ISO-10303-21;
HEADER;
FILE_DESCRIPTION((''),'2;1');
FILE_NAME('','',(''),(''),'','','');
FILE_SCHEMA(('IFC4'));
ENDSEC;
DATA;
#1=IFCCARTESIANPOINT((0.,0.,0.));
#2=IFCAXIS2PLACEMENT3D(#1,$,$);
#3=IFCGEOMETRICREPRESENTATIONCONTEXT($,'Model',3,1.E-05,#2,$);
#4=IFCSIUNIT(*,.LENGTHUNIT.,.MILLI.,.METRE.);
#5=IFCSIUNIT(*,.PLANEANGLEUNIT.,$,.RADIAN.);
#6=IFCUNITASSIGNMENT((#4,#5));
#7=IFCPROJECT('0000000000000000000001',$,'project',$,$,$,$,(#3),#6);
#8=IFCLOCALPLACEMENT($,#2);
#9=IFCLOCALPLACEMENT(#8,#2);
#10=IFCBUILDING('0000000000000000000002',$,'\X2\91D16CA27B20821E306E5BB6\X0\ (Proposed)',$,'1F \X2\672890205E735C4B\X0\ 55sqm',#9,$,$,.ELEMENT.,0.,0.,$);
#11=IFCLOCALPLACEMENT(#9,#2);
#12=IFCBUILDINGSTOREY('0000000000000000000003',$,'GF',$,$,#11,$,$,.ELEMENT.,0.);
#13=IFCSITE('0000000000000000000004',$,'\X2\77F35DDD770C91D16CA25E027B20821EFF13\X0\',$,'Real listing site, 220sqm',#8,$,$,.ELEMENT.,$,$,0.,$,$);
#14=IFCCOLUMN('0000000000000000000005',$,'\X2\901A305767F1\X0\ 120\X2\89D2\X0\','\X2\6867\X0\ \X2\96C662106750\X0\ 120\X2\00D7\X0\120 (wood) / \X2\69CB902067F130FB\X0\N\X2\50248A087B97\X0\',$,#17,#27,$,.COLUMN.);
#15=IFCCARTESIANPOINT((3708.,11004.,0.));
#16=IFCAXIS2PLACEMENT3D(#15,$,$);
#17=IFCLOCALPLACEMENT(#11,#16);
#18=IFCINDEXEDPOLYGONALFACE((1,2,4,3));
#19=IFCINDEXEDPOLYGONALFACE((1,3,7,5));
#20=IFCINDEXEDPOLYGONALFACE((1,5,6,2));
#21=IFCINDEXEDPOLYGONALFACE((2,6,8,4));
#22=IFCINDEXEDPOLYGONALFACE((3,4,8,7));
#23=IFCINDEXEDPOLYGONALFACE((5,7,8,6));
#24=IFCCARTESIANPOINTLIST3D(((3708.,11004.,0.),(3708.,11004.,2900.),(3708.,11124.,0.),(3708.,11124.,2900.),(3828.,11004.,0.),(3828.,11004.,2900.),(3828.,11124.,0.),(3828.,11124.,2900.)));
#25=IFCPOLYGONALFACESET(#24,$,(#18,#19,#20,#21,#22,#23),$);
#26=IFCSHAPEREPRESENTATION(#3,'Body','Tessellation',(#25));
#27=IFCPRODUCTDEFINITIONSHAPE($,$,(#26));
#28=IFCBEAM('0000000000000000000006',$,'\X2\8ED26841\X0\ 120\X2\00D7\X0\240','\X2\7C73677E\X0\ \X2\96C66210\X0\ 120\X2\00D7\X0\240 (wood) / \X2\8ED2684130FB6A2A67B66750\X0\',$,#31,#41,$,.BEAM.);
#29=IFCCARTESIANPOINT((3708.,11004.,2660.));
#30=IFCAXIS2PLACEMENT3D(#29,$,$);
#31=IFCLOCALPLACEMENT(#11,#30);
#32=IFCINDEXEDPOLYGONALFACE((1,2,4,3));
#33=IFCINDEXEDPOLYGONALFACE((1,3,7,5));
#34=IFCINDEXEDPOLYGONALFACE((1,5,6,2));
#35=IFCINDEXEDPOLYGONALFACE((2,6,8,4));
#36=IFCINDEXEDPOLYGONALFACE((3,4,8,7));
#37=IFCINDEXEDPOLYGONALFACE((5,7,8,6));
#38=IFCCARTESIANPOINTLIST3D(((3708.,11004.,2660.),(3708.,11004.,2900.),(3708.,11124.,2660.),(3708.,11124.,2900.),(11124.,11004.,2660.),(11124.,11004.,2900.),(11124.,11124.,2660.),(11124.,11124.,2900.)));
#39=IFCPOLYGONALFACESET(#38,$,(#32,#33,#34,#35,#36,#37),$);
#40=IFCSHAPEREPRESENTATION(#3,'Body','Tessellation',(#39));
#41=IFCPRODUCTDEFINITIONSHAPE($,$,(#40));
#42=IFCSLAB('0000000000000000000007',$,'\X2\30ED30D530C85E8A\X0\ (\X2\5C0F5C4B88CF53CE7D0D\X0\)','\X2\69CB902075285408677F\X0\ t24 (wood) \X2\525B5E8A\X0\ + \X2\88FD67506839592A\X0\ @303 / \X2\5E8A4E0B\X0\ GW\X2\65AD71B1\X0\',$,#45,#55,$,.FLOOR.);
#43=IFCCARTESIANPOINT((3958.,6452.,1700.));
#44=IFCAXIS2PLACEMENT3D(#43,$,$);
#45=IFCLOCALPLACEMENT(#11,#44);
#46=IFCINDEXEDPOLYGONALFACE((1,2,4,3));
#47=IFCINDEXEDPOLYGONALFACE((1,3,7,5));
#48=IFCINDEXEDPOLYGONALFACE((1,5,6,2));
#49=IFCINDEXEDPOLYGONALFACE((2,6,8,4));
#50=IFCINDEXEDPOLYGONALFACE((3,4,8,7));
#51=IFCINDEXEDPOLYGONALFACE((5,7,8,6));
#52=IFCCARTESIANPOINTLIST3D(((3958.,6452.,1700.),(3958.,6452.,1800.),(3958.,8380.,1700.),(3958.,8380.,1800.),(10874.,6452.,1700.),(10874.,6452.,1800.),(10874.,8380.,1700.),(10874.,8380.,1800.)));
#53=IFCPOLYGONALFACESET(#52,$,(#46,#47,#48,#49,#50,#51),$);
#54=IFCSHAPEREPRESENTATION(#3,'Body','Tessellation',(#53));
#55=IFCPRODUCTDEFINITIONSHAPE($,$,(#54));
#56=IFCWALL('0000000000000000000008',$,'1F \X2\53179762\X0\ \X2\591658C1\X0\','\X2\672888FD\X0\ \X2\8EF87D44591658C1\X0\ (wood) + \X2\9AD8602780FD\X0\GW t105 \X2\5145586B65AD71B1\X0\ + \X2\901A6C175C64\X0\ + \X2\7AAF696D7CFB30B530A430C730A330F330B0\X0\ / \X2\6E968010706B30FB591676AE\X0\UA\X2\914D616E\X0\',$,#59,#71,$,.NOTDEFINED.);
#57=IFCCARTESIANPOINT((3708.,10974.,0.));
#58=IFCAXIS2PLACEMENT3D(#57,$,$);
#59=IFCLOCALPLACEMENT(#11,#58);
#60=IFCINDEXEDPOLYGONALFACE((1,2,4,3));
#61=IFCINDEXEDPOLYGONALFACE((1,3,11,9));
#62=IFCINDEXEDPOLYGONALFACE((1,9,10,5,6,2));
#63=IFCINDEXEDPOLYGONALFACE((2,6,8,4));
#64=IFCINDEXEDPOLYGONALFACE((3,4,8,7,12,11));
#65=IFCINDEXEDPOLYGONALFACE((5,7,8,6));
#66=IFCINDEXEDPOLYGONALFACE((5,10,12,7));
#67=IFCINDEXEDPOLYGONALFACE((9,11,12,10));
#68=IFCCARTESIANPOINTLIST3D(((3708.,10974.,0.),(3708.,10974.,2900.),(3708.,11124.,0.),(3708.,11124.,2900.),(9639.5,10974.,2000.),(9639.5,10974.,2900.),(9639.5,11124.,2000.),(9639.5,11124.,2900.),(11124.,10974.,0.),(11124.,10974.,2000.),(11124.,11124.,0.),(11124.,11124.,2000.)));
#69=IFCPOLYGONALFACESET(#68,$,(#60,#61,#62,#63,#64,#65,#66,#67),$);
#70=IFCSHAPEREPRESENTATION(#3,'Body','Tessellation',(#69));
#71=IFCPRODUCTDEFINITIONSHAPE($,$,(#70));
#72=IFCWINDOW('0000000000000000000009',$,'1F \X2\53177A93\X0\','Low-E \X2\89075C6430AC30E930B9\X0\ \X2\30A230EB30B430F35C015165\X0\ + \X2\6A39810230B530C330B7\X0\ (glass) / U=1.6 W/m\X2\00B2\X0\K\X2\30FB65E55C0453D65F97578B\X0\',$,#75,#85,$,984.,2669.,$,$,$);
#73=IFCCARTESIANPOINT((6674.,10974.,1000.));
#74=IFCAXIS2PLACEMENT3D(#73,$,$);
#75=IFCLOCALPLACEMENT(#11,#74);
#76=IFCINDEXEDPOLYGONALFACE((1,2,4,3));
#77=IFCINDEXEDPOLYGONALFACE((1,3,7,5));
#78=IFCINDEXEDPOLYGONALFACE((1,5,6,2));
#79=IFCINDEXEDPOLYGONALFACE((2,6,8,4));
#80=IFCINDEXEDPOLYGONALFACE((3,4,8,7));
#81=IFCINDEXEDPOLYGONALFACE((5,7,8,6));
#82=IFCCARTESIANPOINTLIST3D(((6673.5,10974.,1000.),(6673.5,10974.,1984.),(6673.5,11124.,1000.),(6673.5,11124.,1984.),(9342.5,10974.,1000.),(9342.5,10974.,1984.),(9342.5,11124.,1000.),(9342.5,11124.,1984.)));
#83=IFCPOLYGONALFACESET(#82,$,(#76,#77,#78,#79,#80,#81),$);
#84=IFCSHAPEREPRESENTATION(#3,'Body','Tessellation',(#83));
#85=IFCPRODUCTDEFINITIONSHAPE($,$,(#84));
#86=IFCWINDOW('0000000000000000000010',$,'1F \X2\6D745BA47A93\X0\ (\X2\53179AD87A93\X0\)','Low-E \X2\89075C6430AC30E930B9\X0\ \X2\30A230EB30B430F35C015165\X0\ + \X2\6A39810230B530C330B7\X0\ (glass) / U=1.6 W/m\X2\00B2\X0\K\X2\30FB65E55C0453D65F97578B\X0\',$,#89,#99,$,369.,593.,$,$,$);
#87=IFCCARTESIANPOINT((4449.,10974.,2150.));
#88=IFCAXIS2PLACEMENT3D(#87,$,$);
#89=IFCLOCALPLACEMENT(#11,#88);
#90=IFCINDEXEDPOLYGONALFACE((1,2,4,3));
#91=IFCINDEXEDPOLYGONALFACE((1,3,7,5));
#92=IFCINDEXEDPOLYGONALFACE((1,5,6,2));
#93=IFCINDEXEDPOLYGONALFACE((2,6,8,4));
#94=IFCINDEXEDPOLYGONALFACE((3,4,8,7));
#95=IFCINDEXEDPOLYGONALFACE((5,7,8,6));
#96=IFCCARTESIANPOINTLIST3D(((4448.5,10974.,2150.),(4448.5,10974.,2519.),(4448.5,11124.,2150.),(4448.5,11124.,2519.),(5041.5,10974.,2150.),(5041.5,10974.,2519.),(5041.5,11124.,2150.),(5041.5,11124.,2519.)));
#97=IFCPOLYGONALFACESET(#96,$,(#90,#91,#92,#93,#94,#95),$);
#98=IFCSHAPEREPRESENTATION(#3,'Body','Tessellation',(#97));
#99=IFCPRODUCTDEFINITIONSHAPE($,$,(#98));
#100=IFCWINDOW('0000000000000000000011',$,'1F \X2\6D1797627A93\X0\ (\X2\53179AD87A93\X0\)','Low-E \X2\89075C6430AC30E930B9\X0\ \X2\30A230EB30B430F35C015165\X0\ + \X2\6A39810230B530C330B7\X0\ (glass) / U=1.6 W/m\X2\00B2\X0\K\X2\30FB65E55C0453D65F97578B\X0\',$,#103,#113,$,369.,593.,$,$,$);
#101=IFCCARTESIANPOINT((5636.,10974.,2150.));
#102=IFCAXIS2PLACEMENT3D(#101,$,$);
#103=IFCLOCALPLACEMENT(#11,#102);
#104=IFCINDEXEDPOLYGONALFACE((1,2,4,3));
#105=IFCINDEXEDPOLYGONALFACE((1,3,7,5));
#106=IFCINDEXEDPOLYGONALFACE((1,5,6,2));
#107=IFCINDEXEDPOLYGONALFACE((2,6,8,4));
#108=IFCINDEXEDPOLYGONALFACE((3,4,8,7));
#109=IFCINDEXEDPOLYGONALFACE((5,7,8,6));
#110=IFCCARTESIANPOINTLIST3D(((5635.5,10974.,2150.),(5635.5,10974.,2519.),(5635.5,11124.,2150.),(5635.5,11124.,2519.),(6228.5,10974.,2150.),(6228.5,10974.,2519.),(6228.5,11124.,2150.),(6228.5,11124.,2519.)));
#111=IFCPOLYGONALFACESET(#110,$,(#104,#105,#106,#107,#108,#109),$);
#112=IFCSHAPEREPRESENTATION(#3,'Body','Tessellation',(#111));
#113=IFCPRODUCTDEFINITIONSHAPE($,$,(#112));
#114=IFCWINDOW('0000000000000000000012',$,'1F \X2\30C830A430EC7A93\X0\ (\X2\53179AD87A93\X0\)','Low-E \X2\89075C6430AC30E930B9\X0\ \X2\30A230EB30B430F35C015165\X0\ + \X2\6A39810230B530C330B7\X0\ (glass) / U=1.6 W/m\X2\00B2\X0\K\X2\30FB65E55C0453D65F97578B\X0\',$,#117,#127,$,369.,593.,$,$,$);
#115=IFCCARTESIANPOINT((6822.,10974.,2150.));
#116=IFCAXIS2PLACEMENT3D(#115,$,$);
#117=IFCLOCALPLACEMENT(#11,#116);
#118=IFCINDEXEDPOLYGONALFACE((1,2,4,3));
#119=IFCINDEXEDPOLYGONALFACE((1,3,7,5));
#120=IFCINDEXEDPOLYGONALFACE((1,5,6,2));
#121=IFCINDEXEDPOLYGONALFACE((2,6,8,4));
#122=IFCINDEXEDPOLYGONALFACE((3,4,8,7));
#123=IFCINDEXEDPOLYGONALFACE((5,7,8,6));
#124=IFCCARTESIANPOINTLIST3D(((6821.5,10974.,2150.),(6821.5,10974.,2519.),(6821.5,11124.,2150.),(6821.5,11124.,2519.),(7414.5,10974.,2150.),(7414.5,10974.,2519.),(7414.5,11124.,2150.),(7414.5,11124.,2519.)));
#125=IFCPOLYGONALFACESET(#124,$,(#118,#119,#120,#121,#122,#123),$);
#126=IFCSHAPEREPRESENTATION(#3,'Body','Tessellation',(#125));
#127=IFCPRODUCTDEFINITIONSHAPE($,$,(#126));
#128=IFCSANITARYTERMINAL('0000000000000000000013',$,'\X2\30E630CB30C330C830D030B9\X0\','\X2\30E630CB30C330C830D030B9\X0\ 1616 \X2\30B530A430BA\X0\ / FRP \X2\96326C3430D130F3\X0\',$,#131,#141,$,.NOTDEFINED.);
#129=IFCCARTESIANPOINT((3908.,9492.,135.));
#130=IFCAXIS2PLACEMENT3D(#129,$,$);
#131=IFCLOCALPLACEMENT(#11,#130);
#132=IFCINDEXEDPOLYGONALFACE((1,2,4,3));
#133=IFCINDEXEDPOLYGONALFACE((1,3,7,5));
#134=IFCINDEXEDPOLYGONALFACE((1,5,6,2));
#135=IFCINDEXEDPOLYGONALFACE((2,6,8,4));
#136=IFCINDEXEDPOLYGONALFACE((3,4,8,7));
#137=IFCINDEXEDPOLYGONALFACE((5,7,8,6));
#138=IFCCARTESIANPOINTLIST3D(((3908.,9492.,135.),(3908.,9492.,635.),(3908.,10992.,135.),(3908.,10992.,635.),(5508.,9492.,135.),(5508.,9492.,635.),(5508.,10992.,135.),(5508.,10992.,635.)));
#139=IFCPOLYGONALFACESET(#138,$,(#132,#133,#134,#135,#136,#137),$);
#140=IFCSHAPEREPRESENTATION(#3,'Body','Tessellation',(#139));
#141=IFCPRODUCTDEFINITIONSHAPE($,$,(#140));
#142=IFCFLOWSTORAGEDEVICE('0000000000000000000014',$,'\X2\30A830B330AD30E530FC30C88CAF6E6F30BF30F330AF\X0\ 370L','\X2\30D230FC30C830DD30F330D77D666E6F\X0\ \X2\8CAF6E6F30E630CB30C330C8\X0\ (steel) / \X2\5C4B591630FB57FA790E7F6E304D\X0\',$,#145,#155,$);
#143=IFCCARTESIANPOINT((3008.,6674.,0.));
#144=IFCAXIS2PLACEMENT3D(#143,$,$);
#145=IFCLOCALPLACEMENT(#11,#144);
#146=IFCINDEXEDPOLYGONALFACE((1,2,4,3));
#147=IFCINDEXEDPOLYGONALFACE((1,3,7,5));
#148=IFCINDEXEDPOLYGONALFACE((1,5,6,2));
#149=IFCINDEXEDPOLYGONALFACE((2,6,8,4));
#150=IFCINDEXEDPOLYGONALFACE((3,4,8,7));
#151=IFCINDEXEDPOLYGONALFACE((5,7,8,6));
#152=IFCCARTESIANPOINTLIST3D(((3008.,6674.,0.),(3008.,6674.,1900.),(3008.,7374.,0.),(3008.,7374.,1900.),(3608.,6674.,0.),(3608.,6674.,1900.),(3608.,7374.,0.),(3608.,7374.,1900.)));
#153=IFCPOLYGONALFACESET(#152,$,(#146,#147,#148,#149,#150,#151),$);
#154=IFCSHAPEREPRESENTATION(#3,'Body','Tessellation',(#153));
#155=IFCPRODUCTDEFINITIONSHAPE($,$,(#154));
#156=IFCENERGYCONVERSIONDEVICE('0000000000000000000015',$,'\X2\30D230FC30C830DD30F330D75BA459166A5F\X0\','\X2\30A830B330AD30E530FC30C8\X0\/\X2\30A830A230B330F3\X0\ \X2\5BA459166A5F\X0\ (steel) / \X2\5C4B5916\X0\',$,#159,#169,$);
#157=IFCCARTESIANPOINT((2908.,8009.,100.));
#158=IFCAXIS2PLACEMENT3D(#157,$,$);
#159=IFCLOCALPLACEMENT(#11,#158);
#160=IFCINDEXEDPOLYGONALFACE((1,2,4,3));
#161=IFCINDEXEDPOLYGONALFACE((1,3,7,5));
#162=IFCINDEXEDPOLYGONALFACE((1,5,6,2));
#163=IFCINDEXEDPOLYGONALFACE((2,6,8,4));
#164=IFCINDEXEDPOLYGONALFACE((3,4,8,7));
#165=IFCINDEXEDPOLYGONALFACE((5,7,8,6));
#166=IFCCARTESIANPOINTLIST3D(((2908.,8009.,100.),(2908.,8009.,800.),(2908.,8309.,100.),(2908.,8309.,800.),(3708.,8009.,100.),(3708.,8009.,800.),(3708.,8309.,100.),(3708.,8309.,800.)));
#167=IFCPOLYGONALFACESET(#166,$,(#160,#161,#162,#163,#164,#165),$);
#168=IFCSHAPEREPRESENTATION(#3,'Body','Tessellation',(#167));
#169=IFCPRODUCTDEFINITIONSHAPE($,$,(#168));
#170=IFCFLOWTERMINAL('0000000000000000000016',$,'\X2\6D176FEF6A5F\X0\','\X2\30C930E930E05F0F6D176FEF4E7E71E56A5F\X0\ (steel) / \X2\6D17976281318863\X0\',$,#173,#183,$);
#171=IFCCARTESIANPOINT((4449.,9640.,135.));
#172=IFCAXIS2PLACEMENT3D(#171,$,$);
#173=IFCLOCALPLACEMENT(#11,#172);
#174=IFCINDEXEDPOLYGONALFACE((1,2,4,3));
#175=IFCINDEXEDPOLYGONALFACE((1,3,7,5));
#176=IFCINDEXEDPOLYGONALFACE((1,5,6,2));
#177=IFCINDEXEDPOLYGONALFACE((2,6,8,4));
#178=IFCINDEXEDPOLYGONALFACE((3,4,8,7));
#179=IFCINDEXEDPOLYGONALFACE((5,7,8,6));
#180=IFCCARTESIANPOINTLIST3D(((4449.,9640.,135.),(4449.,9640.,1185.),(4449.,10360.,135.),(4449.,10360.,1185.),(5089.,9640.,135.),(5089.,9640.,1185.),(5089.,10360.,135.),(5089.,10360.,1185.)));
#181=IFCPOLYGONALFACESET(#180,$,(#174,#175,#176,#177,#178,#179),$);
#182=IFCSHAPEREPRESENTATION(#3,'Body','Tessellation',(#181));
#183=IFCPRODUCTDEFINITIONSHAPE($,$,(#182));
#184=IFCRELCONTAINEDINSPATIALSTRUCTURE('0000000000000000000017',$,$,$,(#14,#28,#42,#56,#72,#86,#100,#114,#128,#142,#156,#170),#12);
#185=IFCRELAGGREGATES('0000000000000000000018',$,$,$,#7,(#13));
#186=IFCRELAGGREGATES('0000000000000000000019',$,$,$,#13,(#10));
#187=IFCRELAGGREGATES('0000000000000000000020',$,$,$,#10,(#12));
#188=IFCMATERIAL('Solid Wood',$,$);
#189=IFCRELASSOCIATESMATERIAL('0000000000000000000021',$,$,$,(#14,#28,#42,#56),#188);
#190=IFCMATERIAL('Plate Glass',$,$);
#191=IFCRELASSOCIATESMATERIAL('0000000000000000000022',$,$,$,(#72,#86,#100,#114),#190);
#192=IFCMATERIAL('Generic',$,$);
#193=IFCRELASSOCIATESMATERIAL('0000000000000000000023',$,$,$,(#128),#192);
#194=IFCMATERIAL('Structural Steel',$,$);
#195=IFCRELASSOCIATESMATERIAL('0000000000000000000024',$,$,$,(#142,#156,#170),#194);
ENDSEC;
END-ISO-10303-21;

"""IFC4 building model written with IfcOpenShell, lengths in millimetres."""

from ifc_helpers import new_model, si_unit, frame, frame_2d, origin, place, context, project, spatial, rectangle, extrude, material, element, fill, save


model = new_model("IFC4")

# Units and contexts
model_context = context("Model", 3, precision=1e-05, world=origin())
ifc_project = project(units=[si_unit("LENGTHUNIT", "METRE", prefix="MILLI"), si_unit("PLANEANGLEUNIT", "RADIAN")], contexts=[model_context])

# Site, building, storey
site_placement = place(None, origin())
site = spatial("IfcSite", under=ifc_project, at=site_placement, Name="石川県金沢市笠舞３", ObjectType="Real listing site, 220sqm", CompositionType="ELEMENT", RefElevation=0.0)
building_placement = place(site_placement, origin())
building = spatial("IfcBuilding", under=site, at=building_placement, Name="金沢笠舞の家 (Proposed)", ObjectType="1F 木造平屋 55sqm", CompositionType="ELEMENT", ElevationOfRefHeight=0.0, ElevationOfTerrain=0.0)
storey_placement = place(building_placement, origin())
storey = spatial("IfcBuildingStorey", under=building, at=storey_placement, Name="GF", CompositionType="ELEMENT", Elevation=0.0)

# Column
ifc_material_1 = material(Name="Solid Wood")
column_1_placement = place(storey_placement, frame((3708.0, 11004.0, 0.0)))
element("IfcColumn", 1, at=column_1_placement, inside=storey, material=ifc_material_1, Name="通し柱 120角", Description="桧 集成材 120×120 (wood) / 構造柱・N値計算", PredefinedType="COLUMN", context=model_context, shape_type="SweptSolid", body=[
    extrude(rectangle(XDim=120.0, YDim=120.0, at=frame_2d((60.0, 60.0))), frame((3708.0, 11004.0, 0.0)), (0.0, 0.0, 1.0), 2900.0),
])

# Beam
beam_1_placement = place(storey_placement, frame((3708.0, 11004.0, 2660.0)))
element("IfcBeam", 2, at=beam_1_placement, inside=storey, material=ifc_material_1, Name="軒桁 120×240", Description="米松 集成 120×240 (wood) / 軒桁・横架材", PredefinedType="BEAM", context=model_context, shape_type="SweptSolid", body=[
    extrude(rectangle(XDim=7416.0, YDim=120.0, at=frame_2d((3708.0, 60.0))), frame((3708.0, 11004.0, 2660.0)), (0.0, 0.0, 1.0), 240.0),
])

# Slab
slab_placement = place(storey_placement, frame((3958.0, 6452.0, 1700.0)))
element("IfcSlab", 3, at=slab_placement, inside=storey, material=ifc_material_1, Name="ロフト床 (小屋裏収納)", Description="構造用合板 t24 (wood) 剛床 + 製材根太 @303 / 床下 GW断熱", PredefinedType="FLOOR", context=model_context, shape_type="SweptSolid", body=[
    extrude(rectangle(XDim=6916.0, YDim=1928.0, at=frame_2d((3458.0, 964.0))), frame((3958.0, 6452.0, 1700.0)), (0.0, 0.0, 1.0), 100.0),
])

# Wall, openings, windows
wall_1_placement = place(storey_placement, frame((3708.0, 10974.0, 0.0)))
wall_1 = element("IfcWall", 4, at=wall_1_placement, inside=storey, material=ifc_material_1, Name="1F 北面 外壁", Description="木製 軸組外壁 (wood) + 高性能GW t105 充填断熱 + 通気層 + 窯業系サイディング / 準耐火・外皮UA配慮", PredefinedType="NOTDEFINED", context=model_context, shape_type="SweptSolid", body=[
    extrude(rectangle(XDim=7416.0, YDim=150.0, at=frame_2d((3708.0, 75.0))), frame((3708.0, 10974.0, 0.0)), (0.0, 0.0, 1.0), 2900.0),
])
opening_1_placement = place(storey_placement, frame((6674.0, 10974.0, 1000.0)))
opening_1 = element("IfcOpeningElement", 5, at=opening_1_placement, cuts=wall_1, PredefinedType="NOTDEFINED", context=model_context, shape_type="SweptSolid", body=[
    extrude(rectangle(XDim=2669.0, YDim=150.0, at=frame_2d((1334.0, 75.0))), frame((6674.0, 10974.0, 1000.0)), (0.0, 0.0, 1.0), 984.0),
])
opening_2_placement = place(storey_placement, frame((4449.0, 10974.0, 2150.0)))
opening_2 = element("IfcOpeningElement", 6, at=opening_2_placement, cuts=wall_1, PredefinedType="NOTDEFINED", context=model_context, shape_type="SweptSolid", body=[
    extrude(rectangle(XDim=593.0, YDim=150.0, at=frame_2d((296.0, 75.0))), frame((4449.0, 10974.0, 2150.0)), (0.0, 0.0, 1.0), 369.0),
])
opening_3_placement = place(storey_placement, frame((5636.0, 10974.0, 2150.0)))
opening_3 = element("IfcOpeningElement", 7, at=opening_3_placement, cuts=wall_1, PredefinedType="NOTDEFINED", context=model_context, shape_type="SweptSolid", body=[
    extrude(rectangle(XDim=593.0, YDim=150.0, at=frame_2d((296.0, 75.0))), frame((5636.0, 10974.0, 2150.0)), (0.0, 0.0, 1.0), 369.0),
])
opening_4_placement = place(storey_placement, frame((6822.0, 10974.0, 2150.0)))
opening_4 = element("IfcOpeningElement", 8, at=opening_4_placement, cuts=wall_1, PredefinedType="NOTDEFINED", context=model_context, shape_type="SweptSolid", body=[
    extrude(rectangle(XDim=593.0, YDim=150.0, at=frame_2d((296.0, 75.0))), frame((6822.0, 10974.0, 2150.0)), (0.0, 0.0, 1.0), 369.0),
])
ifc_material_2 = material(Name="Plate Glass")
window_1_placement = place(storey_placement, frame((6674.0, 10974.0, 1000.0)))
window_1 = element("IfcWindow", 9, at=window_1_placement, inside=storey, material=ifc_material_2, Name="1F 北窓", Description="Low-E 複層ガラス アルゴン封入 + 樹脂サッシ (glass) / U=1.6 W/m²K・日射取得型", OverallHeight=984.0, OverallWidth=2669.0, context=model_context, shape_type="SweptSolid", body=[
    extrude(rectangle(XDim=2669.0, YDim=150.0, at=frame_2d((1334.0, 75.0))), frame((6674.0, 10974.0, 1000.0)), (0.0, 0.0, 1.0), 984.0),
])
fill(opening_1, window_1)
window_2_placement = place(storey_placement, frame((4449.0, 10974.0, 2150.0)))
window_2 = element("IfcWindow", 10, at=window_2_placement, inside=storey, material=ifc_material_2, Name="1F 浴室窓 (北高窓)", Description="Low-E 複層ガラス アルゴン封入 + 樹脂サッシ (glass) / U=1.6 W/m²K・日射取得型", OverallHeight=369.0, OverallWidth=593.0, context=model_context, shape_type="SweptSolid", body=[
    extrude(rectangle(XDim=593.0, YDim=150.0, at=frame_2d((296.0, 75.0))), frame((4449.0, 10974.0, 2150.0)), (0.0, 0.0, 1.0), 369.0),
])
fill(opening_2, window_2)
window_3_placement = place(storey_placement, frame((5636.0, 10974.0, 2150.0)))
window_3 = element("IfcWindow", 11, at=window_3_placement, inside=storey, material=ifc_material_2, Name="1F 洗面窓 (北高窓)", Description="Low-E 複層ガラス アルゴン封入 + 樹脂サッシ (glass) / U=1.6 W/m²K・日射取得型", OverallHeight=369.0, OverallWidth=593.0, context=model_context, shape_type="SweptSolid", body=[
    extrude(rectangle(XDim=593.0, YDim=150.0, at=frame_2d((296.0, 75.0))), frame((5636.0, 10974.0, 2150.0)), (0.0, 0.0, 1.0), 369.0),
])
fill(opening_3, window_3)
window_4_placement = place(storey_placement, frame((6822.0, 10974.0, 2150.0)))
window_4 = element("IfcWindow", 12, at=window_4_placement, inside=storey, material=ifc_material_2, Name="1F トイレ窓 (北高窓)", Description="Low-E 複層ガラス アルゴン封入 + 樹脂サッシ (glass) / U=1.6 W/m²K・日射取得型", OverallHeight=369.0, OverallWidth=593.0, context=model_context, shape_type="SweptSolid", body=[
    extrude(rectangle(XDim=593.0, YDim=150.0, at=frame_2d((296.0, 75.0))), frame((6822.0, 10974.0, 2150.0)), (0.0, 0.0, 1.0), 369.0),
])
fill(opening_4, window_4)

# Sanitary terminal
ifc_material_3 = material(Name="Generic")
sanitary_terminal_placement = place(storey_placement, frame((3908.0, 9492.0, 135.0)))
element("IfcSanitaryTerminal", 13, at=sanitary_terminal_placement, inside=storey, material=ifc_material_3, Name="ユニットバス", Description="ユニットバス 1616 サイズ / FRP 防水パン", PredefinedType="NOTDEFINED", context=model_context, shape_type="SweptSolid", body=[
    extrude(rectangle(XDim=1600.0, YDim=1500.0, at=frame_2d((800.0, 750.0))), frame((3908.0, 9492.0, 135.0)), (0.0, 0.0, 1.0), 500.0),
])

# Flow storage device
ifc_material_4 = material(Name="Structural Steel")
flow_storage_device_placement = place(storey_placement, frame((3008.0, 6674.0, 0.0)))
element("IfcFlowStorageDevice", 14, at=flow_storage_device_placement, inside=storey, material=ifc_material_4, Name="エコキュート貯湯タンク 370L", Description="ヒートポンプ給湯 貯湯ユニット (steel) / 屋外・基礎置き", context=model_context, shape_type="SweptSolid", body=[
    extrude(rectangle(XDim=600.0, YDim=700.0, at=frame_2d((300.0, 350.0))), frame((3008.0, 6674.0, 0.0)), (0.0, 0.0, 1.0), 1900.0),
])

# Energy conversion device
energy_conversion_device_placement = place(storey_placement, frame((2908.0, 8009.0, 100.0)))
element("IfcEnergyConversionDevice", 15, at=energy_conversion_device_placement, inside=storey, material=ifc_material_4, Name="ヒートポンプ室外機", Description="エコキュート/エアコン 室外機 (steel) / 屋外", context=model_context, shape_type="SweptSolid", body=[
    extrude(rectangle(XDim=800.0, YDim=300.0, at=frame_2d((400.0, 150.0))), frame((2908.0, 8009.0, 100.0)), (0.0, 0.0, 1.0), 700.0),
])

# Flow terminal
flow_terminal_placement = place(storey_placement, frame((4449.0, 9640.0, 135.0)))
element("IfcFlowTerminal", 16, at=flow_terminal_placement, inside=storey, material=ifc_material_4, Name="洗濯機", Description="ドラム式洗濯乾燥機 (steel) / 洗面脱衣", context=model_context, shape_type="SweptSolid", body=[
    extrude(rectangle(XDim=640.0, YDim=720.0, at=frame_2d((320.0, 360.0))), frame((4449.0, 9640.0, 135.0)), (0.0, 0.0, 1.0), 1050.0),
])

save(model, "model.ifc")
